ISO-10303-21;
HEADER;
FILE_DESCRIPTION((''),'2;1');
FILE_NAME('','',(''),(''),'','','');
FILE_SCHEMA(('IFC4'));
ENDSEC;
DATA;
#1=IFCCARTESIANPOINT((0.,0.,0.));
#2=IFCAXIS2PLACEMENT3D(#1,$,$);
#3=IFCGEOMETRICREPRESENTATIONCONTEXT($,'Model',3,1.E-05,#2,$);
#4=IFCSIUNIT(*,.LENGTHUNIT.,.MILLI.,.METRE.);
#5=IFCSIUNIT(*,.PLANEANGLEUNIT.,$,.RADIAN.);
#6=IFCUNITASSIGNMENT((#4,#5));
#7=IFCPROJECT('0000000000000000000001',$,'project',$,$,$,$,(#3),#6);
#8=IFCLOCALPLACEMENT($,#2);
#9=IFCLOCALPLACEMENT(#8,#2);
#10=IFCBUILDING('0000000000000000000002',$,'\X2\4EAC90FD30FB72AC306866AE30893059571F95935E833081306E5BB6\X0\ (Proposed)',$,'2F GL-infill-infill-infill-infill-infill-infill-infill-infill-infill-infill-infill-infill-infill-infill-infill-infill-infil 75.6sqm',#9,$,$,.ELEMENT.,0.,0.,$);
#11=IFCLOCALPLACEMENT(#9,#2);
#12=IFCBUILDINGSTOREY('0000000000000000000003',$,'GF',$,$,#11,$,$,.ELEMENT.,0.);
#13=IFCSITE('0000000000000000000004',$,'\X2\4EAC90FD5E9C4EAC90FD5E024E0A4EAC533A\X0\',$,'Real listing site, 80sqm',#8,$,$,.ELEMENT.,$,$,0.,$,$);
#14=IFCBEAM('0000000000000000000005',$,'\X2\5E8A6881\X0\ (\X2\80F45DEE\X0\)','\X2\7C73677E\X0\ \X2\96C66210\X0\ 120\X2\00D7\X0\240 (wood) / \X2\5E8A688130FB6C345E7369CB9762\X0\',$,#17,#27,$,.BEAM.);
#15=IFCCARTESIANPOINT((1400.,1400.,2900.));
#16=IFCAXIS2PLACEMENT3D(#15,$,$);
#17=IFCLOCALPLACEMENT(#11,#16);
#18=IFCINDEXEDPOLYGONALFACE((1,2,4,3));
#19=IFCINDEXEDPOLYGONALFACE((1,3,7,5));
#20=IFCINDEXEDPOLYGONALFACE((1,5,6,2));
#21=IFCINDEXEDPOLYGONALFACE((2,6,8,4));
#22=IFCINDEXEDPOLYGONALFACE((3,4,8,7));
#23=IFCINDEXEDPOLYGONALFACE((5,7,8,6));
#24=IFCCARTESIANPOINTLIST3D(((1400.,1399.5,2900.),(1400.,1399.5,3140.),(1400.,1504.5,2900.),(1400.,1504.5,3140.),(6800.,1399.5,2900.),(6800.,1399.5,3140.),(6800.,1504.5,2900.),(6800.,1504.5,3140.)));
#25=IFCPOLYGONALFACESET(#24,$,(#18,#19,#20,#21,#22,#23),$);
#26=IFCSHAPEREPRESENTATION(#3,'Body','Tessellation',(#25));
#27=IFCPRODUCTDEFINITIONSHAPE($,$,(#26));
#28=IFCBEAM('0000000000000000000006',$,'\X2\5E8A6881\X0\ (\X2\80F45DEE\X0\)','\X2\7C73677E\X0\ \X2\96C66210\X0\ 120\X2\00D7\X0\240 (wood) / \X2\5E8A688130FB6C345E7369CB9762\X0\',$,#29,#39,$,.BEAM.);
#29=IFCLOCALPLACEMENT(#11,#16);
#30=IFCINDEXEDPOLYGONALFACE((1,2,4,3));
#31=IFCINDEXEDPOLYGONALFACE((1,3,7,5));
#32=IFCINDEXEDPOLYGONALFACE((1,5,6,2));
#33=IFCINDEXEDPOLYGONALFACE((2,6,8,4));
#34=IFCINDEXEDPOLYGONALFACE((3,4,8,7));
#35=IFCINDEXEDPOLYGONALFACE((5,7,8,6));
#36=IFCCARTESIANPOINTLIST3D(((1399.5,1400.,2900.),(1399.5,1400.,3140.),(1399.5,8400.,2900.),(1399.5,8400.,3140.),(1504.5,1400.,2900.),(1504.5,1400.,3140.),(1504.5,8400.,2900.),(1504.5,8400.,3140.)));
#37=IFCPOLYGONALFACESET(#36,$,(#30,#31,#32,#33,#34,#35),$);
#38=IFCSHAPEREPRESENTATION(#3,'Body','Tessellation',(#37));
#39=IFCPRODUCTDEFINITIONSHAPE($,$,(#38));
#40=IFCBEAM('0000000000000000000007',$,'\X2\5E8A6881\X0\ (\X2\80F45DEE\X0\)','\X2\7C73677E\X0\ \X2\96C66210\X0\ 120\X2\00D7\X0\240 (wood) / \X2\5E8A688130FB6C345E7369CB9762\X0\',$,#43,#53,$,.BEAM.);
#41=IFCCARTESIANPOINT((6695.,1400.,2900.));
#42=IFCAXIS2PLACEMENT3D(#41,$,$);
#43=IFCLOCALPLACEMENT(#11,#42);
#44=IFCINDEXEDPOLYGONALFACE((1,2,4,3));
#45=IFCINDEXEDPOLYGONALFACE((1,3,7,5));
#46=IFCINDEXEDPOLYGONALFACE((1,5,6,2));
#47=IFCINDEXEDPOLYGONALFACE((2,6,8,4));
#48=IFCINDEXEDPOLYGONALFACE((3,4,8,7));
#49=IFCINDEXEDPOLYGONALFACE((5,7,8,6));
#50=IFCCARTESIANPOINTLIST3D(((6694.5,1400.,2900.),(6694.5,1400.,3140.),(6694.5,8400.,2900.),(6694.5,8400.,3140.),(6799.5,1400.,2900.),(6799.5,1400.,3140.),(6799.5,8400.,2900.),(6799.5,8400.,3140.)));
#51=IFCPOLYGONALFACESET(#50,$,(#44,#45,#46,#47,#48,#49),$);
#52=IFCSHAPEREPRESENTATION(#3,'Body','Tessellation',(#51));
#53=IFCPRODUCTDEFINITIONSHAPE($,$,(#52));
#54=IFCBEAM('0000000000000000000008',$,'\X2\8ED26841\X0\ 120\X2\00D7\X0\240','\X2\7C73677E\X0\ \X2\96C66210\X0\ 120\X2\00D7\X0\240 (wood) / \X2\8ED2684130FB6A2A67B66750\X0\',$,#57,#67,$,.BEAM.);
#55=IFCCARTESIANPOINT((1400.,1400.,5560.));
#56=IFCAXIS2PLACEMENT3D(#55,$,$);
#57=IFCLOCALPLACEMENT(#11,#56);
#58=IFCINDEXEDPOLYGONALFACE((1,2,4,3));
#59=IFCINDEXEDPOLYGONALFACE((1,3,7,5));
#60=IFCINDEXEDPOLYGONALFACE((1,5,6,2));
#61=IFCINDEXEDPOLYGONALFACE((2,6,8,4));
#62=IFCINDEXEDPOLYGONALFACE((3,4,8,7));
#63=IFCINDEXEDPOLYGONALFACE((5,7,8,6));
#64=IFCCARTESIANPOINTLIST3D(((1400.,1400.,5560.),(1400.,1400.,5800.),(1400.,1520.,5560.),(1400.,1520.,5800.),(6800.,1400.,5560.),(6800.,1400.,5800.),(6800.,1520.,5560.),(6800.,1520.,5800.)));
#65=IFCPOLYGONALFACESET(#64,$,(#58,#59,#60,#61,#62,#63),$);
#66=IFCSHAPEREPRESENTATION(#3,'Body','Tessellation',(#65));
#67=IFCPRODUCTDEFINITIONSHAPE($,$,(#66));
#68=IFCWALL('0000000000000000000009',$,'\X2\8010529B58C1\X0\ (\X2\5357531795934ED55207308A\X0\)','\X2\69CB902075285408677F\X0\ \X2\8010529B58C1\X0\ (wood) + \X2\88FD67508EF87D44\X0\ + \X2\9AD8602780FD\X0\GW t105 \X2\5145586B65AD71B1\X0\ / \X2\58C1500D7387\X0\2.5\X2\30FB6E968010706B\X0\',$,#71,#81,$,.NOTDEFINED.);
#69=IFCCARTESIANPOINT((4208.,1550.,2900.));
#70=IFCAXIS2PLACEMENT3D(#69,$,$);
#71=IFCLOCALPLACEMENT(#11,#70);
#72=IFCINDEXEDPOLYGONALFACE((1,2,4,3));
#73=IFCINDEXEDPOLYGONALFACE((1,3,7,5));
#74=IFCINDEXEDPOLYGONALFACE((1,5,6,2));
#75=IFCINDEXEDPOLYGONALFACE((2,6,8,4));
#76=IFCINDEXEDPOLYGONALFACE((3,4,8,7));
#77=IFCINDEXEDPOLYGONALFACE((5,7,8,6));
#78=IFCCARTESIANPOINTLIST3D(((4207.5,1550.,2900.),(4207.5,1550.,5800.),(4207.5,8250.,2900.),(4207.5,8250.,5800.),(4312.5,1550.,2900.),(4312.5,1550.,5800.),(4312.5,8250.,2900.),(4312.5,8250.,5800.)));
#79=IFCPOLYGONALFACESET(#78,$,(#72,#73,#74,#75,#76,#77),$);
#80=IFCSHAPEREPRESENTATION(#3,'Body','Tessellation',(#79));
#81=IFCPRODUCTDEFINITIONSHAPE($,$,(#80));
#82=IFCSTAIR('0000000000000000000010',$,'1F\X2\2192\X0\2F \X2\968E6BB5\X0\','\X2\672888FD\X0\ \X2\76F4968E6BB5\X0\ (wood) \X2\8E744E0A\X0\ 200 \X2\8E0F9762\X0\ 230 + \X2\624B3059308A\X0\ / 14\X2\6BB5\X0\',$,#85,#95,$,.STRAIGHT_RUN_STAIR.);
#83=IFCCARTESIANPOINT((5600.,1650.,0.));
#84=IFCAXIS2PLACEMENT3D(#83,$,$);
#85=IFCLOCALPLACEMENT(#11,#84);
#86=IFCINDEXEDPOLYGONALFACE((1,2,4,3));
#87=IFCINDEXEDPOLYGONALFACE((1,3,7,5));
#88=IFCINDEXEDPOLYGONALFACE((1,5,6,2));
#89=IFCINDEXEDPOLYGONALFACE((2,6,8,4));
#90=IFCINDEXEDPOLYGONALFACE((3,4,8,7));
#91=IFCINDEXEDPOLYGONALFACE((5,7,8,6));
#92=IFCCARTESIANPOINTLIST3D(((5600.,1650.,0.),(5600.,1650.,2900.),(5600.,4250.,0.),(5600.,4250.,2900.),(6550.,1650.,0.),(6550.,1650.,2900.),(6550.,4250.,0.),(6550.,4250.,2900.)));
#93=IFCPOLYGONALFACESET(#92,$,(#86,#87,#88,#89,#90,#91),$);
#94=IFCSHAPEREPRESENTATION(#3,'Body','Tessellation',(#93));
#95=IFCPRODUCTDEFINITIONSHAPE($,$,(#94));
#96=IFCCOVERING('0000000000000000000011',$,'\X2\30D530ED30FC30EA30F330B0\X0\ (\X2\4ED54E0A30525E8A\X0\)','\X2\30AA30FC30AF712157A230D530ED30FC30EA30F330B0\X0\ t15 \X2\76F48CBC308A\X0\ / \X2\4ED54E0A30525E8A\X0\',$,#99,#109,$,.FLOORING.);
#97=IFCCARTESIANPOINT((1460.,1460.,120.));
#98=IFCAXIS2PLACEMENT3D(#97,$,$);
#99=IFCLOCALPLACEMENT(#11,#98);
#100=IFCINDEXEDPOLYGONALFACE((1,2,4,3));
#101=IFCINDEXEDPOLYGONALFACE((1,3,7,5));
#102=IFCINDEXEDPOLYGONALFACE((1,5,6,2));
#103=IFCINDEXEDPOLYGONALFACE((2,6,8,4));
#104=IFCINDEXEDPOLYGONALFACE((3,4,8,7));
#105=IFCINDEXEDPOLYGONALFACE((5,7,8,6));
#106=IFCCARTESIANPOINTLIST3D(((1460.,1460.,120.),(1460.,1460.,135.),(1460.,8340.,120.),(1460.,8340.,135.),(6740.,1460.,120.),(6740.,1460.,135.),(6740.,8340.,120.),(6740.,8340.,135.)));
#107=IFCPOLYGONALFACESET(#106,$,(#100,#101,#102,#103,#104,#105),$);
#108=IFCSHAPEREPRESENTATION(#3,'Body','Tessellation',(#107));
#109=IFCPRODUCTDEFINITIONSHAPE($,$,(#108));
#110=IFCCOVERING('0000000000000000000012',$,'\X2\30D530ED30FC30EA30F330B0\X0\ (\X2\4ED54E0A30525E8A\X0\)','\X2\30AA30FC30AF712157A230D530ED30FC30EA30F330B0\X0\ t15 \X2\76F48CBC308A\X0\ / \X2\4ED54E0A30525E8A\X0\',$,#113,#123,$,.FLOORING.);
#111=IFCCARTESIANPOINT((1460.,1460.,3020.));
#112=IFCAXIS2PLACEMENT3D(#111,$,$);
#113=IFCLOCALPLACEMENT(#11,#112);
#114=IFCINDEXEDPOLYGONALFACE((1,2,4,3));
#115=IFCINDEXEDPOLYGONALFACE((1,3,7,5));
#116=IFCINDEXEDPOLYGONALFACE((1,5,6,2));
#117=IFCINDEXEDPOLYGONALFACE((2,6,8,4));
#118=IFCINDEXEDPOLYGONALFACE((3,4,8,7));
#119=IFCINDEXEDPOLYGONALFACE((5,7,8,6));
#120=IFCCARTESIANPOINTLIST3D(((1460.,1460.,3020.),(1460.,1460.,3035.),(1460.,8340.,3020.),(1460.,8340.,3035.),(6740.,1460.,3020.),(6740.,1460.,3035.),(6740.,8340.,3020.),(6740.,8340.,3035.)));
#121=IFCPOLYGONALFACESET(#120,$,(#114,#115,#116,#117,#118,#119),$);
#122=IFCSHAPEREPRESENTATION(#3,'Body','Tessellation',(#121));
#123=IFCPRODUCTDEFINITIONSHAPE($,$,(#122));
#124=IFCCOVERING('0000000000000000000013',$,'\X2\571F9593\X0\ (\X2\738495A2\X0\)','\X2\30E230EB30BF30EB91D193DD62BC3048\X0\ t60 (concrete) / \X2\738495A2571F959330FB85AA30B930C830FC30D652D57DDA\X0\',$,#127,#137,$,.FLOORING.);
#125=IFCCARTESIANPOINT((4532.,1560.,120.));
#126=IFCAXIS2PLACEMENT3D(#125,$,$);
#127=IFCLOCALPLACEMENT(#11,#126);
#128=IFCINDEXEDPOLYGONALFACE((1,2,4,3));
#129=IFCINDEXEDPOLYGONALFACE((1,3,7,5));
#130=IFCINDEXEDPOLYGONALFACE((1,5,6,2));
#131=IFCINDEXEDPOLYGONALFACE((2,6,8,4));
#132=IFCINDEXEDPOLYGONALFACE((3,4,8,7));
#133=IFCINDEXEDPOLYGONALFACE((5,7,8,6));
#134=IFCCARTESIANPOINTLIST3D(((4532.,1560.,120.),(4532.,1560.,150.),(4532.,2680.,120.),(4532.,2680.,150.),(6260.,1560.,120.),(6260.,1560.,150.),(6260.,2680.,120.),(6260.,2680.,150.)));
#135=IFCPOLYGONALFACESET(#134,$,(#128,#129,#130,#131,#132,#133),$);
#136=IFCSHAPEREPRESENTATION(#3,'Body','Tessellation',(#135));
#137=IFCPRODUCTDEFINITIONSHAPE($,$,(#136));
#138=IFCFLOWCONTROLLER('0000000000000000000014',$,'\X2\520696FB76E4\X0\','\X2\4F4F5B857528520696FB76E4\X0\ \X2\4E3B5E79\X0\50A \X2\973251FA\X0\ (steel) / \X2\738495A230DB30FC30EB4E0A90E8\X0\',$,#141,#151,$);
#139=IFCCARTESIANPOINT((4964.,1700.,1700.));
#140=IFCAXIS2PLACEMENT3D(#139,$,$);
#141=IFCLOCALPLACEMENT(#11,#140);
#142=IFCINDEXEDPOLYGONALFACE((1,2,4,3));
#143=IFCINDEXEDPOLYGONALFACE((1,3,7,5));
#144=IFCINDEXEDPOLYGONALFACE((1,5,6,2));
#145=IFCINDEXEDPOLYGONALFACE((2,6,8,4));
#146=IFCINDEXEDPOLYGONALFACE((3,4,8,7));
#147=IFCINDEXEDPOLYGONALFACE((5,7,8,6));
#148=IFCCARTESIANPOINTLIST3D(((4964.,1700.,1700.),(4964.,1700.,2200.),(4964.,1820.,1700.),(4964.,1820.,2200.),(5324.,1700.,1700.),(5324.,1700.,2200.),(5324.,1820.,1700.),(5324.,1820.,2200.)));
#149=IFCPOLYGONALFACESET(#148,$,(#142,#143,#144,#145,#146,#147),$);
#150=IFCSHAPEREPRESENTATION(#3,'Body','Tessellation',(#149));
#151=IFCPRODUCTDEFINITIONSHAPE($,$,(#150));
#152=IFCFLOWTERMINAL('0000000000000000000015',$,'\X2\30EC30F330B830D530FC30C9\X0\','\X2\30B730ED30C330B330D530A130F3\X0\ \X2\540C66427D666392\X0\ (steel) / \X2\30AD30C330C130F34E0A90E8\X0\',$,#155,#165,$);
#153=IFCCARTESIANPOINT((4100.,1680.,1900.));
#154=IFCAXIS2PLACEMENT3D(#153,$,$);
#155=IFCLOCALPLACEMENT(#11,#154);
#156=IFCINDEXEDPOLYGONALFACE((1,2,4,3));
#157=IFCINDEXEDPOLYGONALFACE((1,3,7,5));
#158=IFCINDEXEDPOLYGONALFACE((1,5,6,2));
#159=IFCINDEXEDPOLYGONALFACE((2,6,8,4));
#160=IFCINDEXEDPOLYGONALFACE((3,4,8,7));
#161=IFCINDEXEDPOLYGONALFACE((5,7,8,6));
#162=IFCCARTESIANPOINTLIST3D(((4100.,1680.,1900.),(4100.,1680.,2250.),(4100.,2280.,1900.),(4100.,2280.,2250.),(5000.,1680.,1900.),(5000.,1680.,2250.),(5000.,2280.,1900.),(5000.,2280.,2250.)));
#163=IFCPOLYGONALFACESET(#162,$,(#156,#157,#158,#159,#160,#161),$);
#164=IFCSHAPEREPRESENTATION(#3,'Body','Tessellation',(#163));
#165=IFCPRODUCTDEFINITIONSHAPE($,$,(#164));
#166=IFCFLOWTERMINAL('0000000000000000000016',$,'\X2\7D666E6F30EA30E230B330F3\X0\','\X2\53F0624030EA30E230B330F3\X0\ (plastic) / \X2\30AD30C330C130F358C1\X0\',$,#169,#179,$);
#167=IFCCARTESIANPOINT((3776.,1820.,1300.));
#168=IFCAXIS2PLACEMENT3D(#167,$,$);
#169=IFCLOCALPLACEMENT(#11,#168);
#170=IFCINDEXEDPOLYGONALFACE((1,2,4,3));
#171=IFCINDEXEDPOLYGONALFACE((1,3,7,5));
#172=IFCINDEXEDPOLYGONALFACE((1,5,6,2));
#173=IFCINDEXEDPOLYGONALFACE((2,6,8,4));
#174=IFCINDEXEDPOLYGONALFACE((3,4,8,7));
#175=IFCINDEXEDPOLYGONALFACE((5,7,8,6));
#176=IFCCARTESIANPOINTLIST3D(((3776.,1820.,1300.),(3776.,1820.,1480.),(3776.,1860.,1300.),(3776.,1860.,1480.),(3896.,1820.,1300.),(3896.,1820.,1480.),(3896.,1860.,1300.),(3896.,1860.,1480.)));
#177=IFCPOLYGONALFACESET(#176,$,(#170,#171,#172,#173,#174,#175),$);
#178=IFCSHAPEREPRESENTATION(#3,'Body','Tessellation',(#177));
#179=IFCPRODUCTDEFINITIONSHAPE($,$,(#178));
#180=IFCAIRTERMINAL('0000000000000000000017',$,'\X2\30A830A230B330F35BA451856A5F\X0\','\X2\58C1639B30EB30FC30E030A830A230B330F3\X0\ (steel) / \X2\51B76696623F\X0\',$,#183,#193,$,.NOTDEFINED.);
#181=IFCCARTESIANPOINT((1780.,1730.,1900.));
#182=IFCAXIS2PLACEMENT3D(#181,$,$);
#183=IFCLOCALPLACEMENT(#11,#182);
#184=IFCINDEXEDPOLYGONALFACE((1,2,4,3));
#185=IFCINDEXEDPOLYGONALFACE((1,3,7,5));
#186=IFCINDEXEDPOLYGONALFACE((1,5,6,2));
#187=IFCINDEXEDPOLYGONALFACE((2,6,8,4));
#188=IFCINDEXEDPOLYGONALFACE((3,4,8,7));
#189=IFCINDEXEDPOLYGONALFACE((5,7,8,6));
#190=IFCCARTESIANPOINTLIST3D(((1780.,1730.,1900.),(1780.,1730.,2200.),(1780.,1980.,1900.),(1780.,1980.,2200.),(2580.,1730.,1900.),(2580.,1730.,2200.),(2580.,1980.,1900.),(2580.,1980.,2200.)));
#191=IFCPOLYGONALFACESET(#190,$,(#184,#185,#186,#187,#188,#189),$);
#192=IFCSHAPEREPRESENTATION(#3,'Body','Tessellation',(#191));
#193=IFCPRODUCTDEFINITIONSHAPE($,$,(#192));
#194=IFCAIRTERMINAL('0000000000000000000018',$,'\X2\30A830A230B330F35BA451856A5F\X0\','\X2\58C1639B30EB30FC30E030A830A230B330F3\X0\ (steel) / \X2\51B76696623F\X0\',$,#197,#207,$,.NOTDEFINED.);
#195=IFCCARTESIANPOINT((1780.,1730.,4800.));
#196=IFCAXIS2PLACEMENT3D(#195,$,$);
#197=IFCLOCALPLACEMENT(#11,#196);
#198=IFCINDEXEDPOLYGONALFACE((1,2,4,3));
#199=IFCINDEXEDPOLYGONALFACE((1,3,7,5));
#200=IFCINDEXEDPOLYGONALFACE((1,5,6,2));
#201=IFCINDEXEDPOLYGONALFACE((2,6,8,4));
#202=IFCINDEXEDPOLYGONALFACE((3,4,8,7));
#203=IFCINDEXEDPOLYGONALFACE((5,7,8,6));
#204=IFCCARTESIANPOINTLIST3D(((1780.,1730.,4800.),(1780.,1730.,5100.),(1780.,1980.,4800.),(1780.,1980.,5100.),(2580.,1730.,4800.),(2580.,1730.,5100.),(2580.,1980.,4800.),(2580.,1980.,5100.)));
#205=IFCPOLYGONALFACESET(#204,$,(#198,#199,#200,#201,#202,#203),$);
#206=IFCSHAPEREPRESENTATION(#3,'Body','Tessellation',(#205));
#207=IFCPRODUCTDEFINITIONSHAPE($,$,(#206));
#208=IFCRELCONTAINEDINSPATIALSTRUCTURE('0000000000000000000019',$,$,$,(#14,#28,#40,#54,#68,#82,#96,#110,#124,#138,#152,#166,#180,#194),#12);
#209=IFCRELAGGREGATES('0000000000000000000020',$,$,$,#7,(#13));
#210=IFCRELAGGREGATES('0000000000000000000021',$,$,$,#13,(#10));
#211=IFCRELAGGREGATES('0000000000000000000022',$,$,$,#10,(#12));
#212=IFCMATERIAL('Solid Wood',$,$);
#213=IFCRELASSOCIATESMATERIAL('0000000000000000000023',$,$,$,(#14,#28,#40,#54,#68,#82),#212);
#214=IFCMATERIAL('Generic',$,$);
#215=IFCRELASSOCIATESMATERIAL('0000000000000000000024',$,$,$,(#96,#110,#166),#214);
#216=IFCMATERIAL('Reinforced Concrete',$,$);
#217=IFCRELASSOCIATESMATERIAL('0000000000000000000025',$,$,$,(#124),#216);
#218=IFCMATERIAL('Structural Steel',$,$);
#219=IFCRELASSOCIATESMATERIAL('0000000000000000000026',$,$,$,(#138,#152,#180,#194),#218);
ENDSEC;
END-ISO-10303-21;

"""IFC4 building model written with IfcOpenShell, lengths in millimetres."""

from ifc_helpers import new_model, si_unit, frame, frame_2d, origin, place, context, project, spatial, rectangle, extrude, material, element, save


model = new_model("IFC4")

# Units and contexts
model_context = context("Model", 3, precision=1e-05, world=origin())
ifc_project = project(units=[si_unit("LENGTHUNIT", "METRE", prefix="MILLI"), si_unit("PLANEANGLEUNIT", "RADIAN")], contexts=[model_context])

# Site, building, storey
site_placement = place(None, origin())
site = spatial("IfcSite", under=ifc_project, at=site_placement, Name="京都府京都市上京区", ObjectType="Real listing site, 80sqm", CompositionType="ELEMENT", RefElevation=0.0)
building_placement = place(site_placement, origin())
building = spatial("IfcBuilding", under=site, at=building_placement, Name="京都・犬と暮らす土間広めの家 (Proposed)", ObjectType="2F GL-infill-infill-infill-infill-infill-infill-infill-infill-infill-infill-infill-infill-infill-infill-infill-infill-infil 75.6sqm", CompositionType="ELEMENT", ElevationOfRefHeight=0.0, ElevationOfTerrain=0.0)
storey_placement = place(building_placement, origin())
storey = spatial("IfcBuildingStorey", under=building, at=storey_placement, Name="GF", CompositionType="ELEMENT", Elevation=0.0)

# Shared definitions
ifc_material_1 = material(Name="Solid Wood")

# Beams
beam_1_placement = place(storey_placement, frame((1400.0, 1400.0, 2900.0)))
element("IfcBeam", 1, at=beam_1_placement, inside=storey, material=ifc_material_1, Name="床梁 (胴差)", Description="米松 集成 120×240 (wood) / 床梁・水平構面", PredefinedType="BEAM", context=model_context, shape_type="SweptSolid", body=[
    extrude(rectangle(XDim=5400.0, YDim=105.0, at=frame_2d((2700.0, 52.0))), frame((1400.0, 1400.0, 2900.0)), (0.0, 0.0, 1.0), 240.0),
])
beam_2_placement = place(storey_placement, frame((1400.0, 1400.0, 2900.0)))
element("IfcBeam", 2, at=beam_2_placement, inside=storey, material=ifc_material_1, Name="床梁 (胴差)", Description="米松 集成 120×240 (wood) / 床梁・水平構面", PredefinedType="BEAM", context=model_context, shape_type="SweptSolid", body=[
    extrude(rectangle(XDim=105.0, YDim=7000.0, at=frame_2d((52.0, 3500.0))), frame((1400.0, 1400.0, 2900.0)), (0.0, 0.0, 1.0), 240.0),
])
beam_3_placement = place(storey_placement, frame((6695.0, 1400.0, 2900.0)))
element("IfcBeam", 3, at=beam_3_placement, inside=storey, material=ifc_material_1, Name="床梁 (胴差)", Description="米松 集成 120×240 (wood) / 床梁・水平構面", PredefinedType="BEAM", context=model_context, shape_type="SweptSolid", body=[
    extrude(rectangle(XDim=105.0, YDim=7000.0, at=frame_2d((52.0, 3500.0))), frame((6695.0, 1400.0, 2900.0)), (0.0, 0.0, 1.0), 240.0),
])
beam_4_placement = place(storey_placement, frame((1400.0, 1400.0, 5560.0)))
element("IfcBeam", 4, at=beam_4_placement, inside=storey, material=ifc_material_1, Name="軒桁 120×240", Description="米松 集成 120×240 (wood) / 軒桁・横架材", PredefinedType="BEAM", context=model_context, shape_type="SweptSolid", body=[
    extrude(rectangle(XDim=5400.0, YDim=120.0, at=frame_2d((2700.0, 60.0))), frame((1400.0, 1400.0, 5560.0)), (0.0, 0.0, 1.0), 240.0),
])

# Wall
wall_1_placement = place(storey_placement, frame((4208.0, 1550.0, 2900.0)))
element("IfcWall", 5, at=wall_1_placement, inside=storey, material=ifc_material_1, Name="耐力壁 (南北間仕切り)", Description="構造用合板 耐力壁 (wood) + 製材軸組 + 高性能GW t105 充填断熱 / 壁倍率2.5・準耐火", PredefinedType="NOTDEFINED", context=model_context, shape_type="SweptSolid", body=[
    extrude(rectangle(XDim=105.0, YDim=6700.0, at=frame_2d((52.0, 3350.0))), frame((4208.0, 1550.0, 2900.0)), (0.0, 0.0, 1.0), 2900.0),
])

# Stair
stair_placement = place(storey_placement, frame((5600.0, 1650.0, 0.0)))
element("IfcStair", 6, at=stair_placement, inside=storey, material=ifc_material_1, Name="1F→2F 階段", Description="木製 直階段 (wood) 蹴上 200 踏面 230 + 手すり / 14段", PredefinedType="STRAIGHT_RUN_STAIR", context=model_context, shape_type="SweptSolid", body=[
    extrude(rectangle(XDim=950.0, YDim=2600.0, at=frame_2d((475.0, 1300.0))), frame((5600.0, 1650.0, 0.0)), (0.0, 0.0, 1.0), 2900.0),
])

# Coverings
ifc_material_2 = material(Name="Generic")
covering_1_placement = place(storey_placement, frame((1460.0, 1460.0, 120.0)))
element("IfcCovering", 7, at=covering_1_placement, inside=storey, material=ifc_material_2, Name="フローリング (仕上げ床)", Description="オーク無垢フローリング t15 直貼り / 仕上げ床", PredefinedType="FLOORING", context=model_context, shape_type="SweptSolid", body=[
    extrude(rectangle(XDim=5280.0, YDim=6880.0, at=frame_2d((2640.0, 3440.0))), frame((1460.0, 1460.0, 120.0)), (0.0, 0.0, 1.0), 15.0),
])
covering_2_placement = place(storey_placement, frame((1460.0, 1460.0, 3020.0)))
element("IfcCovering", 8, at=covering_2_placement, inside=storey, material=ifc_material_2, Name="フローリング (仕上げ床)", Description="オーク無垢フローリング t15 直貼り / 仕上げ床", PredefinedType="FLOORING", context=model_context, shape_type="SweptSolid", body=[
    extrude(rectangle(XDim=5280.0, YDim=6880.0, at=frame_2d((2640.0, 3440.0))), frame((1460.0, 1460.0, 3020.0)), (0.0, 0.0, 1.0), 15.0),
])
ifc_material_3 = material(Name="Reinforced Concrete")
covering_3_placement = place(storey_placement, frame((4532.0, 1560.0, 120.0)))
element("IfcCovering", 9, at=covering_3_placement, inside=storey, material=ifc_material_3, Name="土間 (玄関)", Description="モルタル金鏝押え t60 (concrete) / 玄関土間・薪ストーブ動線", PredefinedType="FLOORING", context=model_context, shape_type="SweptSolid", body=[
    extrude(rectangle(XDim=1728.0, YDim=1120.0, at=frame_2d((864.0, 560.0))), frame((4532.0, 1560.0, 120.0)), (0.0, 0.0, 1.0), 30.0),
])

# Flow controller
ifc_material_4 = material(Name="Structural Steel")
flow_controller_placement = place(storey_placement, frame((4964.0, 1700.0, 1700.0)))
element("IfcFlowController", 10, at=flow_controller_placement, inside=storey, material=ifc_material_4, Name="分電盤", Description="住宅用分電盤 主幹50A 露出 (steel) / 玄関ホール上部", context=model_context, shape_type="SweptSolid", body=[
    extrude(rectangle(XDim=360.0, YDim=120.0, at=frame_2d((180.0, 60.0))), frame((4964.0, 1700.0, 1700.0)), (0.0, 0.0, 1.0), 500.0),
])

# Flow terminals
flow_terminal_1_placement = place(storey_placement, frame((4100.0, 1680.0, 1900.0)))
element("IfcFlowTerminal", 11, at=flow_terminal_1_placement, inside=storey, material=ifc_material_4, Name="レンジフード", Description="シロッコファン 同時給排 (steel) / キッチン上部", context=model_context, shape_type="SweptSolid", body=[
    extrude(rectangle(XDim=900.0, YDim=600.0, at=frame_2d((450.0, 300.0))), frame((4100.0, 1680.0, 1900.0)), (0.0, 0.0, 1.0), 350.0),
])
flow_terminal_2_placement = place(storey_placement, frame((3776.0, 1820.0, 1300.0)))
element("IfcFlowTerminal", 12, at=flow_terminal_2_placement, inside=storey, material=ifc_material_2, Name="給湯リモコン", Description="台所リモコン (plastic) / キッチン壁", context=model_context, shape_type="SweptSolid", body=[
    extrude(rectangle(XDim=120.0, YDim=40.0, at=frame_2d((60.0, 20.0))), frame((3776.0, 1820.0, 1300.0)), (0.0, 0.0, 1.0), 180.0),
])

# Air terminals
air_terminal_1_placement = place(storey_placement, frame((1780.0, 1730.0, 1900.0)))
element("IfcAirTerminal", 13, at=air_terminal_1_placement, inside=storey, material=ifc_material_4, Name="エアコン室内機", Description="壁掛ルームエアコン (steel) / 冷暖房", PredefinedType="NOTDEFINED", context=model_context, shape_type="SweptSolid", body=[
    extrude(rectangle(XDim=800.0, YDim=250.0, at=frame_2d((400.0, 125.0))), frame((1780.0, 1730.0, 1900.0)), (0.0, 0.0, 1.0), 300.0),
])
air_terminal_2_placement = place(storey_placement, frame((1780.0, 1730.0, 4800.0)))
element("IfcAirTerminal", 14, at=air_terminal_2_placement, inside=storey, material=ifc_material_4, Name="エアコン室内機", Description="壁掛ルームエアコン (steel) / 冷暖房", PredefinedType="NOTDEFINED", context=model_context, shape_type="SweptSolid", body=[
    extrude(rectangle(XDim=800.0, YDim=250.0, at=frame_2d((400.0, 125.0))), frame((1780.0, 1730.0, 4800.0)), (0.0, 0.0, 1.0), 300.0),
])

save(model, "model.ifc")
